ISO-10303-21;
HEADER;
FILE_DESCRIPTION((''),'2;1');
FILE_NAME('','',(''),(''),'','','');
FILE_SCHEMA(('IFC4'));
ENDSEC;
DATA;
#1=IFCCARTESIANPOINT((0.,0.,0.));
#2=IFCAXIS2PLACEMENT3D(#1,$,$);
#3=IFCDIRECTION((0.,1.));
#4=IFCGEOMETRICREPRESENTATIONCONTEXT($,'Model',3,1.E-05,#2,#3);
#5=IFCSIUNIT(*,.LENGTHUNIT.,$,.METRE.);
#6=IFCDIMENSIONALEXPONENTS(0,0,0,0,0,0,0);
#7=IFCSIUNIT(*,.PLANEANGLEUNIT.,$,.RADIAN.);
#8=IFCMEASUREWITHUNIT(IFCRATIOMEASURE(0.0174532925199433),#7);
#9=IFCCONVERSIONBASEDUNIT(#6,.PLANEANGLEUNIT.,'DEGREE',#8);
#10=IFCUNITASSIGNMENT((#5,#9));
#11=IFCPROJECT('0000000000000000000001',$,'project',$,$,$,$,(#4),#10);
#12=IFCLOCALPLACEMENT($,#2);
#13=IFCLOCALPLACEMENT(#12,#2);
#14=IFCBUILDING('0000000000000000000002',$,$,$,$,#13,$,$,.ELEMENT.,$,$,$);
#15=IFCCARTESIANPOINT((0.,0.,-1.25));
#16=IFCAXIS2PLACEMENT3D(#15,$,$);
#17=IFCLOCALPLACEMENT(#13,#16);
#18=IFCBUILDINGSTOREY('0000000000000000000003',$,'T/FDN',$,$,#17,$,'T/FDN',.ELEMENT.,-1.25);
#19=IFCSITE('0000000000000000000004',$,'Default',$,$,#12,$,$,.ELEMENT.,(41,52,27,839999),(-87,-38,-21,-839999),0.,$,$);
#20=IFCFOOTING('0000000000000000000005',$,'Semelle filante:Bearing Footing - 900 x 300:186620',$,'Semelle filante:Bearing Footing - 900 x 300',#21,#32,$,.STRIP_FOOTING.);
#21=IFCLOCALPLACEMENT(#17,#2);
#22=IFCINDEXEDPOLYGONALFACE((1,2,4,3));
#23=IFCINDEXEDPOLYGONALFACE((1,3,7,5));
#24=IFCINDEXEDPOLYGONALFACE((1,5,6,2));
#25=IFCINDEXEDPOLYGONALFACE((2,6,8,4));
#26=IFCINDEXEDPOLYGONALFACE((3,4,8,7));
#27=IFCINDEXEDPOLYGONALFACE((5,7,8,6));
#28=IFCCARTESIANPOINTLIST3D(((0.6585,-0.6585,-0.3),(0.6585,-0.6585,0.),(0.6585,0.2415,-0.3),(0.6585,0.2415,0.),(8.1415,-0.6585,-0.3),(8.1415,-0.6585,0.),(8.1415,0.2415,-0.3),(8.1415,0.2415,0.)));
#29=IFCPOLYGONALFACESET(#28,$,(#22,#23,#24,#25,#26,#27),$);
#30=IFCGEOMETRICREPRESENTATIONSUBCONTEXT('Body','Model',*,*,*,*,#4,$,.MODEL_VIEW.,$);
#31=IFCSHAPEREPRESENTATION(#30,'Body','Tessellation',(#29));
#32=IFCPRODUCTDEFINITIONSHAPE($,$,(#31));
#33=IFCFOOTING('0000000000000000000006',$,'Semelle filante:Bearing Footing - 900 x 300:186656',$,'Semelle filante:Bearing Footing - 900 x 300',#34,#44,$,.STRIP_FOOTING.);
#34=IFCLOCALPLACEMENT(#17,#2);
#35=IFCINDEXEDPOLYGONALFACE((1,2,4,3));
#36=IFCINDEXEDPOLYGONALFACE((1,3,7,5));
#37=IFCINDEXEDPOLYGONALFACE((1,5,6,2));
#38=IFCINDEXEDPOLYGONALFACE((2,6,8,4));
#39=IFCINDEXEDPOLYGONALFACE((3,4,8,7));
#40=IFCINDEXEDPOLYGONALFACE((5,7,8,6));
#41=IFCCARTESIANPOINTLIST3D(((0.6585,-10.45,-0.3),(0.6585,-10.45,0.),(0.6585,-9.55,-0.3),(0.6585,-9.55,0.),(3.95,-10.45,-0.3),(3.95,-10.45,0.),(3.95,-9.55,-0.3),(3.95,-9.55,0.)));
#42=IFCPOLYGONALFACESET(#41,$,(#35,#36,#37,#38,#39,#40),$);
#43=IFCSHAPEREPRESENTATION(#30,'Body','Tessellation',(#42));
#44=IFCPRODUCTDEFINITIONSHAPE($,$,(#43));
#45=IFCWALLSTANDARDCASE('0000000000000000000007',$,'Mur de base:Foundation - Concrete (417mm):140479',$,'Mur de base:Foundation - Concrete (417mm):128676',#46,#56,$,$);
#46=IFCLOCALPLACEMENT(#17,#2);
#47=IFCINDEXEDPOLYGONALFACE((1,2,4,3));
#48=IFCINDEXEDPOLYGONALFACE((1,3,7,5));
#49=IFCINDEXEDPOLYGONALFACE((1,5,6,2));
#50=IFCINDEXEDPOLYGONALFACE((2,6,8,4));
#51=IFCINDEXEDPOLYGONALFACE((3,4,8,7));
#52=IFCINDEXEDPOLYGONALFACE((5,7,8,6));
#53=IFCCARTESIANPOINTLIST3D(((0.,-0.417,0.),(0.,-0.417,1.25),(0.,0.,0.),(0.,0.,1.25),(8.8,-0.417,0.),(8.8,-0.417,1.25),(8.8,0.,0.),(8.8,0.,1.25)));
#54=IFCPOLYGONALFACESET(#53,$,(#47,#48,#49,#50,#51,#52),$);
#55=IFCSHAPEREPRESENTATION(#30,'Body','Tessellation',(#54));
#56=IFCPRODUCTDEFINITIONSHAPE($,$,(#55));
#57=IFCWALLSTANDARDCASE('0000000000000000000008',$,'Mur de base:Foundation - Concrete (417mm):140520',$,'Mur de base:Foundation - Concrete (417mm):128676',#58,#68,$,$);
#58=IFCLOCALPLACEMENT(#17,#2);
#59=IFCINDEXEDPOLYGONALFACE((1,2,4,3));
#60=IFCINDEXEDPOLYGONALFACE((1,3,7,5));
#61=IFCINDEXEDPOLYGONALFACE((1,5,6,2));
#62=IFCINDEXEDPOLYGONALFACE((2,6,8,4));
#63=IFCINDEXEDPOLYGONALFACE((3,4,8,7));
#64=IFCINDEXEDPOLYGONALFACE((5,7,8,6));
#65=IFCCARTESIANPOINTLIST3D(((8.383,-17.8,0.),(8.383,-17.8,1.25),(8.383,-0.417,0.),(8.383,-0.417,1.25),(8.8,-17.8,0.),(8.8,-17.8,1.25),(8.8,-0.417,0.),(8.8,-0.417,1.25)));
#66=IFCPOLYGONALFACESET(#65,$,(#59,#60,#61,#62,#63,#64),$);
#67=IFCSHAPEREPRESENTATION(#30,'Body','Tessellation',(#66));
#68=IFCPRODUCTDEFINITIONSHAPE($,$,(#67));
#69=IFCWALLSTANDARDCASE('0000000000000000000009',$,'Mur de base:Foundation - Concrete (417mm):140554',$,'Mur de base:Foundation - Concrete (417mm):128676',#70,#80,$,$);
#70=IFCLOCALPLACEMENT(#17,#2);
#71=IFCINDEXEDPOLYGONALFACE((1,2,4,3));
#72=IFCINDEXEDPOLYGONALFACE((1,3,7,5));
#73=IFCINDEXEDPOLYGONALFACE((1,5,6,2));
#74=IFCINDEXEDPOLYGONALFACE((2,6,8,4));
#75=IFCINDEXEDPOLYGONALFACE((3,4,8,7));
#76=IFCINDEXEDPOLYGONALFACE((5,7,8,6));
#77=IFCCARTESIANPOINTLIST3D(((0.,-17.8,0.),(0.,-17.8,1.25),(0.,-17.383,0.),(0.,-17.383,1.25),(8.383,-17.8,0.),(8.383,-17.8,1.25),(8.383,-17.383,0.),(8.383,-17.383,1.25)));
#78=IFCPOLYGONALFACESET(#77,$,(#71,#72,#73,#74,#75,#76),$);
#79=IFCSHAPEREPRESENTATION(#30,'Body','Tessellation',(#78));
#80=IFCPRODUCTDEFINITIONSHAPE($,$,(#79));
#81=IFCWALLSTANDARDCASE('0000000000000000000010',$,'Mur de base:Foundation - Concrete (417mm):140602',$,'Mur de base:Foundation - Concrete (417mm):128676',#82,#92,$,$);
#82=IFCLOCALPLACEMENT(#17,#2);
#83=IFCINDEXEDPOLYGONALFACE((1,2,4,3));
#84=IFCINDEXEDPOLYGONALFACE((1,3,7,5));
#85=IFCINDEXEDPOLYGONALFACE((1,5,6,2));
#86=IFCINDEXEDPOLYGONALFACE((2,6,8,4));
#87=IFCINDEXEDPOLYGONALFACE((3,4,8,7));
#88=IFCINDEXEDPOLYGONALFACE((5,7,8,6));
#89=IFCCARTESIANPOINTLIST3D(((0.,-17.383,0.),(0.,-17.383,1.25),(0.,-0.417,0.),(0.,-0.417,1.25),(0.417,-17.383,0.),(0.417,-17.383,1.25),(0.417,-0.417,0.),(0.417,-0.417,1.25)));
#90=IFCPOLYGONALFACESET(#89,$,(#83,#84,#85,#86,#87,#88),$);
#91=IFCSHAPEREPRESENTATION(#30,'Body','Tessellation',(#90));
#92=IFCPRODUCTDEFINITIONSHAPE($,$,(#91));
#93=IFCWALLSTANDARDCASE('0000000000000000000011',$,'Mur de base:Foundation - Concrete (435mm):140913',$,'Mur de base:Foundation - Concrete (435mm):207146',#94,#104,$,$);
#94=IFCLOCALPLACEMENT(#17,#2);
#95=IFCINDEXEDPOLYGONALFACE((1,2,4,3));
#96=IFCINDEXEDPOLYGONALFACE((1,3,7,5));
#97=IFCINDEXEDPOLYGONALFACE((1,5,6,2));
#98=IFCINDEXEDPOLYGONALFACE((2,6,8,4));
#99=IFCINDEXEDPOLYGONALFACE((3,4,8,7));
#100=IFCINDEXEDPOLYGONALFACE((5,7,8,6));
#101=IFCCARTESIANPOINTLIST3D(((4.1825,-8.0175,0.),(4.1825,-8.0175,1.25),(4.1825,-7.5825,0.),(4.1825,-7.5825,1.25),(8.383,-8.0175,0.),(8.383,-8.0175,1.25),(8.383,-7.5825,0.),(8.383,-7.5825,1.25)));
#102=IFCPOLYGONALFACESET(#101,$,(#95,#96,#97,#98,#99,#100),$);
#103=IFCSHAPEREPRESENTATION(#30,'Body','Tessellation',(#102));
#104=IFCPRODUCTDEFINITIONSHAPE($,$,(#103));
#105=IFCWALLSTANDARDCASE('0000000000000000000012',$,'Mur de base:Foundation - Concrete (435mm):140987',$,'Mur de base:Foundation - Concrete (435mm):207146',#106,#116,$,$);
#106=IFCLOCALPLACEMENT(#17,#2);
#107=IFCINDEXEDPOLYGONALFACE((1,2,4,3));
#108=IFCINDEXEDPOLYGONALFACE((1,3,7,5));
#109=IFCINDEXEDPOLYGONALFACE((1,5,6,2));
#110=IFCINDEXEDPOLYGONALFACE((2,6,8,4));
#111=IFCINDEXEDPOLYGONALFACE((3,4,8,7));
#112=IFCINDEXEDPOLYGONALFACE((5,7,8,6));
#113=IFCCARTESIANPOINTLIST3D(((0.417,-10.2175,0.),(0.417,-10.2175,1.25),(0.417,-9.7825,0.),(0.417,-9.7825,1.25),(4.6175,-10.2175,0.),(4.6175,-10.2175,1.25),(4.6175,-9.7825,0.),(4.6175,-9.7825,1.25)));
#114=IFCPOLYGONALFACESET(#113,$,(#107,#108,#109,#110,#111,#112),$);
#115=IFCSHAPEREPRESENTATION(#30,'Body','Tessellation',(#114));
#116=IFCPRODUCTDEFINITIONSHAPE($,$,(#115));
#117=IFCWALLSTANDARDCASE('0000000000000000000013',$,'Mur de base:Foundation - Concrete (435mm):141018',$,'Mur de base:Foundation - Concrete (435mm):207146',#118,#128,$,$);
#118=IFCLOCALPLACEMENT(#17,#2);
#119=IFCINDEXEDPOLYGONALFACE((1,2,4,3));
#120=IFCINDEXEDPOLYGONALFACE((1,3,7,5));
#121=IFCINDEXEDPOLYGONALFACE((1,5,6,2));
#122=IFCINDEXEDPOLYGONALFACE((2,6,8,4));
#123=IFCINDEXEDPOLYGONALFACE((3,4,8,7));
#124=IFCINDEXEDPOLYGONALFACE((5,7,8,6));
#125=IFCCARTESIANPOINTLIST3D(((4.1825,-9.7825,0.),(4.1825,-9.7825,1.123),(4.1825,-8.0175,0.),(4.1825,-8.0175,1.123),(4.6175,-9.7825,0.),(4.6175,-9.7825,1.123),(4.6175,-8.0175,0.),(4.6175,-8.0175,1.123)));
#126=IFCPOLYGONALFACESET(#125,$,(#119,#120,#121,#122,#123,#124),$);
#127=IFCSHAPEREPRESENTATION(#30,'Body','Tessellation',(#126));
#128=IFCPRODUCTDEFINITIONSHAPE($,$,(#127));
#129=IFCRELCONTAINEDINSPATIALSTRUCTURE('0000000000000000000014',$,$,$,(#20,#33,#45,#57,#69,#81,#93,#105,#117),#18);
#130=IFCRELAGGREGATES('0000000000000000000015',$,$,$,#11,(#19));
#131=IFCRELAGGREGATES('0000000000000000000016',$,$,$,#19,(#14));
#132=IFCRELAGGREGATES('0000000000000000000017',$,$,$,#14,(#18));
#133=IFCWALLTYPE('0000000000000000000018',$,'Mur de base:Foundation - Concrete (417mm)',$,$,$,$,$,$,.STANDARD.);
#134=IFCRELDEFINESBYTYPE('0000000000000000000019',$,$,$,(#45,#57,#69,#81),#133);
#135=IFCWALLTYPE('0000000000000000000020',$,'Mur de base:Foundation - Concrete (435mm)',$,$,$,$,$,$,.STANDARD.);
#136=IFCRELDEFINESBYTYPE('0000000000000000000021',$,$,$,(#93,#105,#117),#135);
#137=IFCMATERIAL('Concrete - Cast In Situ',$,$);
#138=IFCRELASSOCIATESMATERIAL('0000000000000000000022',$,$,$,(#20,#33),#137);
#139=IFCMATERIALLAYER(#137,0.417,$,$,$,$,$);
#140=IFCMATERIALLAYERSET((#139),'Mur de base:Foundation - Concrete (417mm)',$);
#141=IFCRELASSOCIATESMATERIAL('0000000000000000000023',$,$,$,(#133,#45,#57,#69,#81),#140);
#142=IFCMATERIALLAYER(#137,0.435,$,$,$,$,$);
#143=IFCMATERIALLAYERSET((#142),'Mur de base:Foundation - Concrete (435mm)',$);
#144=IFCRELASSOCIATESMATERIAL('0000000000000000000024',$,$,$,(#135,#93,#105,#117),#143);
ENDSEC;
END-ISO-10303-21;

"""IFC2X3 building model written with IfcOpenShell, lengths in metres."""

from ifc_helpers import new_model, entity, si_unit, converted_unit, direction, frame, frame_2d, origin, place, context, subcontext, project, spatial, rectangle, extrude, material, layer, layer_set, layer_usage, type_object, element, save


model = new_model("IFC2X3")

# Units and contexts
model_context = context("Model", 3, precision=1e-05, world=origin(), true_north=direction((0.0, 1.0)))
body_context = subcontext(model_context, "Body", "Model", "MODEL_VIEW")
ifc_project = project(units=[si_unit("LENGTHUNIT", "METRE"), converted_unit("PLANEANGLEUNIT", "DEGREE", entity("IfcRatioMeasure", 0.0174532925199433), si_unit("PLANEANGLEUNIT", "RADIAN"), dimensions=[0, 0, 0, 0, 0, 0, 0])], contexts=[model_context])

# Site, building, storey
site_placement = place(None, origin())
site = spatial("IfcSite", under=ifc_project, at=site_placement, Name="Default", CompositionType="ELEMENT", RefLatitude=(41, 52, 27, 839999), RefLongitude=(-87, -38, -21, -839999), RefElevation=0.0)
building_placement = place(site_placement, origin())
building = spatial("IfcBuilding", under=site, at=building_placement, CompositionType="ELEMENT")
storey_placement = place(building_placement, frame((0.0, 0.0, -1.25)))
storey = spatial("IfcBuildingStorey", under=building, at=storey_placement, Name="T/FDN", LongName="T/FDN", CompositionType="ELEMENT", Elevation=-1.25)

# Footings
ifc_material = material(Name="Concrete - Cast In Situ")
footing_1_placement = place(storey_placement, origin())
element("IfcFooting", 1, at=footing_1_placement, inside=storey, material=ifc_material, Name="Semelle filante:Bearing Footing - 900 x 300:186620", ObjectType="Semelle filante:Bearing Footing - 900 x 300", PredefinedType="STRIP_FOOTING", context=body_context, shape_type="SweptSolid", body=[
    extrude(rectangle(XDim=7.483, YDim=0.9, at=frame_2d((0.0, 0.0), x_axis=(1.0, 0.0))), frame((4.4, -0.2085, -0.3), z_axis=(0.0, 0.0, 1.0), x_axis=(-1.0, 0.0, 0.0)), (0.0, 0.0, 1.0), 0.3),
])
footing_2_placement = place(storey_placement, origin())
element("IfcFooting", 2, at=footing_2_placement, inside=storey, material=ifc_material, Name="Semelle filante:Bearing Footing - 900 x 300:186656", ObjectType="Semelle filante:Bearing Footing - 900 x 300", PredefinedType="STRIP_FOOTING", context=body_context, shape_type="SweptSolid", body=[
    extrude(rectangle(XDim=3.2915, YDim=0.9, at=frame_2d((0.0, 0.0), x_axis=(1.0, 0.0))), frame((2.3043, -10.0, -0.3)), (0.0, 0.0, 1.0), 0.3),
])

# Walls
ifc_layer_1 = layer(ifc_material, 0.417)
ifc_layer_set_1 = layer_set([ifc_layer_1], Name="Mur de base:Foundation - Concrete (417mm)")
ifc_layer_usage_1 = layer_usage(ifc_layer_set_1, "AXIS2", "NEGATIVE", 0.2085)
wall_type_1 = type_object("IfcWallType", Name="Mur de base:Foundation - Concrete (417mm)", PredefinedType="STANDARD", material=ifc_layer_set_1)
wall_1_placement = place(storey_placement, frame((0.0, -0.2085, 0.0)))
element("IfcWallStandardCase", 3, at=wall_1_placement, inside=storey, type_object=wall_type_1, material=ifc_layer_usage_1, Name="Mur de base:Foundation - Concrete (417mm):140479", ObjectType="Mur de base:Foundation - Concrete (417mm):128676", context=body_context, shape_type="SweptSolid", body=[
    extrude(rectangle(XDim=8.8, YDim=0.417, at=frame_2d((4.4, 0.0), x_axis=(-1.0, 0.0))), origin(), (0.0, 0.0, 1.0), 1.25),
])
ifc_layer_usage_2 = layer_usage(ifc_layer_set_1, "AXIS2", "NEGATIVE", 0.2085)
wall_2_placement = place(storey_placement, frame((8.5915, -0.417, 0.0), z_axis=(0.0, 0.0, 1.0), x_axis=(0.0, -1.0, 0.0)))
element("IfcWallStandardCase", 4, at=wall_2_placement, inside=storey, type_object=wall_type_1, material=ifc_layer_usage_2, Name="Mur de base:Foundation - Concrete (417mm):140520", ObjectType="Mur de base:Foundation - Concrete (417mm):128676", context=body_context, shape_type="SweptSolid", body=[
    extrude(rectangle(XDim=17.383, YDim=0.417, at=frame_2d((8.6915, 0.0), x_axis=(-1.0, 0.0))), origin(), (0.0, 0.0, 1.0), 1.25),
])
ifc_layer_usage_3 = layer_usage(ifc_layer_set_1, "AXIS2", "NEGATIVE", 0.2085)
wall_3_placement = place(storey_placement, frame((8.383, -17.5915, 0.0), z_axis=(0.0, 0.0, 1.0), x_axis=(-1.0, 0.0, 0.0)))
element("IfcWallStandardCase", 5, at=wall_3_placement, inside=storey, type_object=wall_type_1, material=ifc_layer_usage_3, Name="Mur de base:Foundation - Concrete (417mm):140554", ObjectType="Mur de base:Foundation - Concrete (417mm):128676", context=body_context, shape_type="SweptSolid", body=[
    extrude(rectangle(XDim=8.383, YDim=0.417, at=frame_2d((4.1915, 0.0), x_axis=(-1.0, 0.0))), origin(), (0.0, 0.0, 1.0), 1.25),
])
ifc_layer_usage_4 = layer_usage(ifc_layer_set_1, "AXIS2", "NEGATIVE", 0.2085)
wall_4_placement = place(storey_placement, frame((0.2085, -17.383, 0.0), z_axis=(0.0, 0.0, 1.0), x_axis=(0.0, 1.0, 0.0)))
element("IfcWallStandardCase", 6, at=wall_4_placement, inside=storey, type_object=wall_type_1, material=ifc_layer_usage_4, Name="Mur de base:Foundation - Concrete (417mm):140602", ObjectType="Mur de base:Foundation - Concrete (417mm):128676", context=body_context, shape_type="SweptSolid", body=[
    extrude(rectangle(XDim=16.966, YDim=0.417, at=frame_2d((8.483, 0.0), x_axis=(-1.0, 0.0))), origin(), (0.0, 0.0, 1.0), 1.25),
])
ifc_layer_2 = layer(ifc_material, 0.435)
ifc_layer_set_2 = layer_set([ifc_layer_2], Name="Mur de base:Foundation - Concrete (435mm)")
ifc_layer_usage_5 = layer_usage(ifc_layer_set_2, "AXIS2", "NEGATIVE", 0.2175)
wall_type_2 = type_object("IfcWallType", Name="Mur de base:Foundation - Concrete (435mm)", PredefinedType="STANDARD", material=ifc_layer_set_2)
wall_5_placement = place(storey_placement, frame((8.383, -7.8, 0.0), z_axis=(0.0, 0.0, 1.0), x_axis=(-1.0, 0.0, 0.0)))
element("IfcWallStandardCase", 7, at=wall_5_placement, inside=storey, type_object=wall_type_2, material=ifc_layer_usage_5, Name="Mur de base:Foundation - Concrete (435mm):140913", ObjectType="Mur de base:Foundation - Concrete (435mm):207146", context=body_context, shape_type="SweptSolid", body=[
    extrude(rectangle(XDim=4.2005, YDim=0.435, at=frame_2d((2.1002, 0.0), x_axis=(-1.0, 0.0))), origin(), (0.0, 0.0, 1.0), 1.25),
])
ifc_layer_usage_6 = layer_usage(ifc_layer_set_2, "AXIS2", "NEGATIVE", 0.2175)
wall_6_placement = place(storey_placement, frame((0.417, -10.0, 0.0)))
element("IfcWallStandardCase", 8, at=wall_6_placement, inside=storey, type_object=wall_type_2, material=ifc_layer_usage_6, Name="Mur de base:Foundation - Concrete (435mm):140987", ObjectType="Mur de base:Foundation - Concrete (435mm):207146", context=body_context, shape_type="SweptSolid", body=[
    extrude(rectangle(XDim=4.2005, YDim=0.435, at=frame_2d((2.1002, 0.0), x_axis=(-1.0, 0.0))), origin(), (0.0, 0.0, 1.0), 1.25),
])
ifc_layer_usage_7 = layer_usage(ifc_layer_set_2, "AXIS2", "NEGATIVE", 0.2175)
wall_7_placement = place(storey_placement, frame((4.4, -9.7825, 0.0), z_axis=(0.0, 0.0, 1.0), x_axis=(0.0, 1.0, 0.0)))
element("IfcWallStandardCase", 9, at=wall_7_placement, inside=storey, type_object=wall_type_2, material=ifc_layer_usage_7, Name="Mur de base:Foundation - Concrete (435mm):141018", ObjectType="Mur de base:Foundation - Concrete (435mm):207146", context=body_context, shape_type="SweptSolid", body=[
    extrude(rectangle(XDim=1.765, YDim=0.435, at=frame_2d((0.8825, 0.0), x_axis=(-1.0, 0.0))), origin(), (0.0, 0.0, 1.0), 1.123),
])

save(model, "model.ifc")
